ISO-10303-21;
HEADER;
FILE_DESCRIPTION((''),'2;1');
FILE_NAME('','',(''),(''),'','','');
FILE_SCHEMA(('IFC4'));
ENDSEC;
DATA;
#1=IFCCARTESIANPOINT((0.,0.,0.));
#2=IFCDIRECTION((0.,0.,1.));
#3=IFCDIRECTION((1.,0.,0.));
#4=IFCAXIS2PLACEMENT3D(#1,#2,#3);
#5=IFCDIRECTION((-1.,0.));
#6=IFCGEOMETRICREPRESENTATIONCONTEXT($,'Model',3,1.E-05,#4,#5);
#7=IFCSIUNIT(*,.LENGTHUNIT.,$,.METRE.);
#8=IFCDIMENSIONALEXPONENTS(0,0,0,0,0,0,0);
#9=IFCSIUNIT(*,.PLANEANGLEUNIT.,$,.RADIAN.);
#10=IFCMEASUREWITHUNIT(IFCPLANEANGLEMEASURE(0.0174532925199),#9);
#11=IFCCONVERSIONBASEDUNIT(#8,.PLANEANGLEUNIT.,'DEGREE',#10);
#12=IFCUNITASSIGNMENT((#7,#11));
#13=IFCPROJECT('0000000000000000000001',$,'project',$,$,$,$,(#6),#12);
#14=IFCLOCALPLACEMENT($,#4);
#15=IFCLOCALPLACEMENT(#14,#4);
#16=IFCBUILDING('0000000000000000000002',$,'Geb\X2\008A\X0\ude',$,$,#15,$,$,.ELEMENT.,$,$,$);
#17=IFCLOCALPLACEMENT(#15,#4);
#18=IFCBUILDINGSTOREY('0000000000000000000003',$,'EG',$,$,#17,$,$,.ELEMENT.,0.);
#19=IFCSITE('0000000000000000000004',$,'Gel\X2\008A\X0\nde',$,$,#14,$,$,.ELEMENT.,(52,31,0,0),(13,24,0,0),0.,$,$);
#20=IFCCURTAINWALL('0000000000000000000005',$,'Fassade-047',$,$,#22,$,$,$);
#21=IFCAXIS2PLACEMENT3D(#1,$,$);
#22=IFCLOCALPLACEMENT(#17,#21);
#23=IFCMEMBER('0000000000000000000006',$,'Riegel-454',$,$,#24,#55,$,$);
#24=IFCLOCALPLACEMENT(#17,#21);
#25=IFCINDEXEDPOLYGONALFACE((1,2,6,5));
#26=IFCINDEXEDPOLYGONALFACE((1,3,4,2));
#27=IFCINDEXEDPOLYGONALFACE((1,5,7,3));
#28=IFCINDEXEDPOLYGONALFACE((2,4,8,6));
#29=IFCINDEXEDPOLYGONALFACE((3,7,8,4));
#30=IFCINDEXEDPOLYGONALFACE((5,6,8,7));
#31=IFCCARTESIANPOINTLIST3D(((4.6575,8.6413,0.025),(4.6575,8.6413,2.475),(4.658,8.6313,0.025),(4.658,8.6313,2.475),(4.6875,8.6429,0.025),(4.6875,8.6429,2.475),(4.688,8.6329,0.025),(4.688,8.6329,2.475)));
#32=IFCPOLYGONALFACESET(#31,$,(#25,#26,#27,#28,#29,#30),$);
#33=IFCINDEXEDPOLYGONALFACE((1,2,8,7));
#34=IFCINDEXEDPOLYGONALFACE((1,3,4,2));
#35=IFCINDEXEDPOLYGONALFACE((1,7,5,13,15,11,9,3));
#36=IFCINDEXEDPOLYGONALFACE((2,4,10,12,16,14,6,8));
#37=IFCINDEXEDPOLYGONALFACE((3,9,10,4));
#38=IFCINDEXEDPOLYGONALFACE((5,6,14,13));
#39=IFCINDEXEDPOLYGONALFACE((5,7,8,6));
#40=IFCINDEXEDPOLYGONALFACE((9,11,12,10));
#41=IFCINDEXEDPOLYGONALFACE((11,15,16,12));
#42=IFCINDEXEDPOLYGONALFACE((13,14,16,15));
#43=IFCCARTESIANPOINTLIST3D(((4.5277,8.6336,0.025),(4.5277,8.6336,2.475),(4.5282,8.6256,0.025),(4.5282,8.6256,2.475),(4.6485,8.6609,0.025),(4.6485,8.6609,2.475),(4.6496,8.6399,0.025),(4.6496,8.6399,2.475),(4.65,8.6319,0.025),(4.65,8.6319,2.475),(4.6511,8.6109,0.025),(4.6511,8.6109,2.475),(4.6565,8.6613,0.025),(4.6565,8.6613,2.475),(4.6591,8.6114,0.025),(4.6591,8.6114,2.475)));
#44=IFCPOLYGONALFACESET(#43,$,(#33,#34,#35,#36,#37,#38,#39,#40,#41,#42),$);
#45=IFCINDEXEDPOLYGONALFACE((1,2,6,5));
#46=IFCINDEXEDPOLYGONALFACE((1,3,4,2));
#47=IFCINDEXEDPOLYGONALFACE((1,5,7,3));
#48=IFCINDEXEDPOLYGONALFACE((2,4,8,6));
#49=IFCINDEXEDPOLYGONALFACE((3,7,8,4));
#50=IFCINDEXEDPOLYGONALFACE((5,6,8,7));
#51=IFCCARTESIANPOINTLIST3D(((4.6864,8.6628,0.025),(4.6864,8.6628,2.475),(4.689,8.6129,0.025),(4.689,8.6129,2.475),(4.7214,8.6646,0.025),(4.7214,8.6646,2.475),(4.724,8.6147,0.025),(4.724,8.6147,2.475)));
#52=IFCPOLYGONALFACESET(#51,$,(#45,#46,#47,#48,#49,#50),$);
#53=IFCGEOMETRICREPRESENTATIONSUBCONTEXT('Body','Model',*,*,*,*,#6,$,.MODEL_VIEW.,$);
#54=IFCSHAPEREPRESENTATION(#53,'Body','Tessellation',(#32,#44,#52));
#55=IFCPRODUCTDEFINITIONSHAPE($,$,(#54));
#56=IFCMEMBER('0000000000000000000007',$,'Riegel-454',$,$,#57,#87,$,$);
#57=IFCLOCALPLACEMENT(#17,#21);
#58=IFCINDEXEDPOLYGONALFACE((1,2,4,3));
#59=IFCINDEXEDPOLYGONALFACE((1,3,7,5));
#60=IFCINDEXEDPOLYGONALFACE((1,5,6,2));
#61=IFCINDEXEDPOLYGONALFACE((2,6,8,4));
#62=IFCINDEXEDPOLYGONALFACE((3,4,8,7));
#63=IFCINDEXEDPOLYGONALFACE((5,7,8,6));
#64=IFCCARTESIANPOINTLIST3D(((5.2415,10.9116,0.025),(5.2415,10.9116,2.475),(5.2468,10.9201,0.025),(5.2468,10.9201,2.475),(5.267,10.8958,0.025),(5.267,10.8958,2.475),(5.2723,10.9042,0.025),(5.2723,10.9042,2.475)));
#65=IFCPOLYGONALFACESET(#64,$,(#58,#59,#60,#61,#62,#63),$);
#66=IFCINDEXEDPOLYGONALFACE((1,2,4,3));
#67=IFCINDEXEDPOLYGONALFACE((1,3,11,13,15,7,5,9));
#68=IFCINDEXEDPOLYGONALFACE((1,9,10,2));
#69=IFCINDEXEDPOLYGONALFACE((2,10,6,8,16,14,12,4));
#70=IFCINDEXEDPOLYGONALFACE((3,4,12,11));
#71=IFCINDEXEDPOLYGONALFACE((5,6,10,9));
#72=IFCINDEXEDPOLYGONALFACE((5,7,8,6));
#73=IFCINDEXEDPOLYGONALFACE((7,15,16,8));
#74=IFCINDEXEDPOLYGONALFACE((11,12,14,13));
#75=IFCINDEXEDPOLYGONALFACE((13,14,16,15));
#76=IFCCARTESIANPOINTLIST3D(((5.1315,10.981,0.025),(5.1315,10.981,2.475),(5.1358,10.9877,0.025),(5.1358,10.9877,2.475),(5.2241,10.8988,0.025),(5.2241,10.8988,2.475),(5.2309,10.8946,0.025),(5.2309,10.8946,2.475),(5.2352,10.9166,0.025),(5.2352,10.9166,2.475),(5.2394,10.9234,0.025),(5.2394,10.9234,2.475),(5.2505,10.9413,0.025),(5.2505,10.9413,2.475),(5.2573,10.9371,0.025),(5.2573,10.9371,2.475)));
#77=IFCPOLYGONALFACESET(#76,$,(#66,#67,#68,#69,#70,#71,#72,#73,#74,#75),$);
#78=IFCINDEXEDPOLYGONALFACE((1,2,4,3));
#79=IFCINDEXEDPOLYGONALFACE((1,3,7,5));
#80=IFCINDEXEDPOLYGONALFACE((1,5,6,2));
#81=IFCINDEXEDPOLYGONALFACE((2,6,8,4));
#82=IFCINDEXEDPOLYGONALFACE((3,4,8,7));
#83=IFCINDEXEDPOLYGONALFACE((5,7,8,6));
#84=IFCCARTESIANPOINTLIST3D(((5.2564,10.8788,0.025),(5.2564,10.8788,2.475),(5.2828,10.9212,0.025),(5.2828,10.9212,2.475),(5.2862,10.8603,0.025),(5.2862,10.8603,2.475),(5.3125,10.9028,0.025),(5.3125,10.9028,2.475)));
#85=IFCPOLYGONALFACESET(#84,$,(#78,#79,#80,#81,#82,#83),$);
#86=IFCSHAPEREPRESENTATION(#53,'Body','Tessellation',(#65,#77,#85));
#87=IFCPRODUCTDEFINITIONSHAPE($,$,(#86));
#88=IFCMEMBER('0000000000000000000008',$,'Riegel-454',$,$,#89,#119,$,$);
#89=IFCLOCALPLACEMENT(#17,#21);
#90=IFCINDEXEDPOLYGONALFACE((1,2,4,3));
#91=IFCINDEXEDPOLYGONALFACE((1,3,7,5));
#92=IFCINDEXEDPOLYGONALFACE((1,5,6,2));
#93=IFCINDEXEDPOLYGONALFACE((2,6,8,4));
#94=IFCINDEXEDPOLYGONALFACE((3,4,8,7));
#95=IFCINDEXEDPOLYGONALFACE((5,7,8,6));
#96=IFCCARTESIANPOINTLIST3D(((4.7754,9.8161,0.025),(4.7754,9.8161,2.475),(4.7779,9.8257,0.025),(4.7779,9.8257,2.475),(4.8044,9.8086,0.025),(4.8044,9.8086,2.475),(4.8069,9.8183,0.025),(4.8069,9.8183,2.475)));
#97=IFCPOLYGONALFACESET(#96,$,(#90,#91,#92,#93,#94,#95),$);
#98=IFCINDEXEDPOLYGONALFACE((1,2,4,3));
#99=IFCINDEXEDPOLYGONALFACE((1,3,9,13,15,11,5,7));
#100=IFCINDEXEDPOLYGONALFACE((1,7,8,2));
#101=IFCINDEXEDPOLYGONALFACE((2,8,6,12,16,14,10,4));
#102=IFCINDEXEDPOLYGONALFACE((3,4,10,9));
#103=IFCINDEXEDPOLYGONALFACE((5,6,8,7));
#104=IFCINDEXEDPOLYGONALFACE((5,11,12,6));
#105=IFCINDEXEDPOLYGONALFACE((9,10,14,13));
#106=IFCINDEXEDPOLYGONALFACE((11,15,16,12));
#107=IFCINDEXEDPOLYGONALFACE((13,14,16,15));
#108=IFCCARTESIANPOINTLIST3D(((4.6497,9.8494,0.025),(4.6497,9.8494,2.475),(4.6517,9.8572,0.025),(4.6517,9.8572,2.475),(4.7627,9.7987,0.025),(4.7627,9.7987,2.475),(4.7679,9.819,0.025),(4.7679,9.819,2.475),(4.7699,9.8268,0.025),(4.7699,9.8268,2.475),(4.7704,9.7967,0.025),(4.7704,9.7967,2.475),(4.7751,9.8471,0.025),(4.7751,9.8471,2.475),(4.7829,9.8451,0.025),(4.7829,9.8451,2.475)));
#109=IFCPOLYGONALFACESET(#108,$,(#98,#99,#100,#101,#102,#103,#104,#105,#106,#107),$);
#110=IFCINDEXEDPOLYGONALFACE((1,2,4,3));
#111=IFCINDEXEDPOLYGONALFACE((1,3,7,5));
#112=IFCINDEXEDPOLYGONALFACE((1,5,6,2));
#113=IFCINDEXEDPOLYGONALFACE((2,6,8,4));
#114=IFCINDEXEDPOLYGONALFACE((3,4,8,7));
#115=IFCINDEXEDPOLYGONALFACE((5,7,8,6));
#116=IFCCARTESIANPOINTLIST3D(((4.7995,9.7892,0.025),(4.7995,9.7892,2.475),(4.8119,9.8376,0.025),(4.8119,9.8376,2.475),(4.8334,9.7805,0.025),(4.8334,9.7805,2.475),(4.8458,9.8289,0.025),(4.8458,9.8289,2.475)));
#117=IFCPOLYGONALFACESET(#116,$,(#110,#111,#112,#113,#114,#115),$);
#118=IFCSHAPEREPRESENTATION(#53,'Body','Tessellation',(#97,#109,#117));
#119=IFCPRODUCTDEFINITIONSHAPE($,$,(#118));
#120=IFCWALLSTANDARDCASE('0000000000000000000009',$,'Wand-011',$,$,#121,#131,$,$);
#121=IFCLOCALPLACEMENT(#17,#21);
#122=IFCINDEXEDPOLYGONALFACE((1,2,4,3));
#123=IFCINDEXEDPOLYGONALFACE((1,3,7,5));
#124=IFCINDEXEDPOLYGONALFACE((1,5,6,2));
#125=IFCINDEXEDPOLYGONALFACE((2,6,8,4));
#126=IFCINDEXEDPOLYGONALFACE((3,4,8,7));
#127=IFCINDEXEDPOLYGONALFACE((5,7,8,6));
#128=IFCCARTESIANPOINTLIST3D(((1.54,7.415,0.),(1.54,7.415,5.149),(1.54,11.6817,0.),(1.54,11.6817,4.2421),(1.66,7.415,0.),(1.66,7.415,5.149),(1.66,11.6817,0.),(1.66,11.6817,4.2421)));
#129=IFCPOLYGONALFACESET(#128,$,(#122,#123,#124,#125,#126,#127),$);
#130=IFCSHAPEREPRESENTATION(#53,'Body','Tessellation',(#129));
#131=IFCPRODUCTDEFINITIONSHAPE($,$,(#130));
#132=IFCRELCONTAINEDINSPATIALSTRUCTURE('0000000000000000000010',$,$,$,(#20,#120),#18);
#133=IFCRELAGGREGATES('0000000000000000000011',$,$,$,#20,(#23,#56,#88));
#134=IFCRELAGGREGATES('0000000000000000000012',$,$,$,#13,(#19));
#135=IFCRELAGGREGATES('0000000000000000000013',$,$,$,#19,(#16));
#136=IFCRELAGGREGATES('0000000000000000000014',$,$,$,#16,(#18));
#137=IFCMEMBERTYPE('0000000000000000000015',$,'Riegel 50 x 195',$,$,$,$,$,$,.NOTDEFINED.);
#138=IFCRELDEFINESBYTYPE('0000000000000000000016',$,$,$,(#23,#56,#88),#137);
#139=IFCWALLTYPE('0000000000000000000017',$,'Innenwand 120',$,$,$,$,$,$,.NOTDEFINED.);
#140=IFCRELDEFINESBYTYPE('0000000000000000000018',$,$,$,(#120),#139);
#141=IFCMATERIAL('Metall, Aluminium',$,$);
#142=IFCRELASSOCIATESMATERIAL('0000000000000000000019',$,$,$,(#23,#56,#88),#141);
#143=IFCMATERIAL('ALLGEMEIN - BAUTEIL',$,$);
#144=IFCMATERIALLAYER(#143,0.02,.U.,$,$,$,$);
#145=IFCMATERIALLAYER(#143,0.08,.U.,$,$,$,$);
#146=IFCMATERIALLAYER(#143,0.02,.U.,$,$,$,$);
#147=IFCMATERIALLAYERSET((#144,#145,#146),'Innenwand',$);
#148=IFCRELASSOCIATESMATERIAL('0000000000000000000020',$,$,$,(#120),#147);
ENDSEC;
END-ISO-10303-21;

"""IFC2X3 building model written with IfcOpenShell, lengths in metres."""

from ifc_helpers import new_model, entity, si_unit, converted_unit, direction, frame, origin_with_axes, place, context, subcontext, project, spatial, polyline, outline, extrude, clip, halfspace, material, layer, layer_set, layer_usage, type_object, element, aggregate, save


model = new_model("IFC2X3")

# Units and contexts
model_context = context("Model", 3, precision=1e-05, world=origin_with_axes(), true_north=direction((-1.0, 0.0)))
body_context = subcontext(model_context, "Body", "Model", "MODEL_VIEW")
ifc_project = project(units=[si_unit("LENGTHUNIT", "METRE"), converted_unit("PLANEANGLEUNIT", "DEGREE", entity("IfcPlaneAngleMeasure", 0.0174532925199), si_unit("PLANEANGLEUNIT", "RADIAN"), dimensions=[0, 0, 0, 0, 0, 0, 0])], contexts=[model_context])

# Site, building, storey
site_placement = place(None, origin_with_axes())
site = spatial("IfcSite", under=ifc_project, at=site_placement, Name="Gel\u008ande", CompositionType="ELEMENT", RefLatitude=(52, 31, 0, 0), RefLongitude=(13, 24, 0, 0), RefElevation=0.0)
building_placement = place(site_placement, origin_with_axes())
building = spatial("IfcBuilding", under=site, at=building_placement, Name="Geb\u008aude", CompositionType="ELEMENT")
storey_placement = place(building_placement, origin_with_axes())
storey = spatial("IfcBuildingStorey", under=building, at=storey_placement, Name="EG", CompositionType="ELEMENT", Elevation=0.0)

# Curtain wall, members
curtain_wall_placement = place(storey_placement, frame((7.6056, 12.5904, 0.0), z_axis=(0.0, 0.0, 1.0), x_axis=(1.0, 0.0, 0.0)))
curtain_wall = element("IfcCurtainWall", 1, at=curtain_wall_placement, inside=storey, Name="Fassade-047")
ifc_material_1 = material(Name="Metall, Aluminium")
member_type_1 = type_object("IfcMemberType", Name="Riegel 50 x 195", PredefinedType="NOTDEFINED")
member_1_placement = place(curtain_wall_placement, frame((-2.9328, -3.9533, 0.0), z_axis=(0.0, 0.0, 1.0), x_axis=(-0.051729, 0.998661, 0.0)))
member_1 = element("IfcMember", 2, at=member_1_placement, type_object=member_type_1, material=ifc_material_1, Name="Riegel-454", context=body_context, shape_type="SweptSolid", body=[
    extrude(outline(polyline([(-0.0152, 0.0042), (-0.0147, -0.0058), (0.0152, -0.0042), (0.0147, 0.0058), (-0.0152, 0.0042)])), frame((0.0, 0.0, 0.025), z_axis=(0.0, 0.0, 1.0), x_axis=(-0.051729, -0.998661, 0.0)), (0.0, 0.0, 1.0), 2.45),
    extrude(outline(polyline([(-0.145, -0.0035), (-0.1446, -0.0115), (-0.0228, -0.0052), (-0.0217, -0.0262), (-0.0137, -0.0257), (-0.0163, 0.0242), (-0.0243, 0.0238), (-0.0232, 0.0028), (-0.145, -0.0035)])), frame((0.0, 0.0, 0.025), z_axis=(0.0, 0.0, 1.0), x_axis=(-0.051729, -0.998661, 0.0)), (0.0, 0.0, 1.0), 2.45),
    extrude(outline(polyline([(0.0512, -0.0224), (0.0486, 0.0276), (0.0137, 0.0257), (0.0163, -0.0242), (0.0512, -0.0224)])), frame((0.0, 0.0, 0.025), z_axis=(0.0, 0.0, 1.0), x_axis=(-0.051729, -0.998661, 0.0)), (0.0, 0.0, 1.0), 2.45),
])
member_2_placement = place(curtain_wall_placement, frame((-2.3487, -1.6825, 0.0), z_axis=(0.0, 0.0, 1.0), x_axis=(0.527191, 0.849747, 0.0)))
member_2 = element("IfcMember", 3, at=member_2_placement, type_object=member_type_1, material=ifc_material_1, Name="Riegel-454", context=body_context, shape_type="SweptSolid", body=[
    extrude(outline(polyline([(-0.0101, 0.0122), (-0.0154, 0.0037), (0.0101, -0.0122), (0.0154, -0.0037), (-0.0101, 0.0122)])), frame((0.0, 0.0, 0.025), z_axis=(0.0, 0.0, 1.0), x_axis=(0.527191, -0.849747, 0.0)), (0.0, 0.0, 1.0), 2.45),
    extrude(outline(polyline([(-0.1211, 0.0798), (-0.1253, 0.073), (-0.0217, 0.0087), (-0.0327, -0.0091), (-0.0259, -0.0133), (0.0004, 0.0292), (-0.0064, 0.0334), (-0.0174, 0.0155), (-0.1211, 0.0798)])), frame((0.0, 0.0, 0.025), z_axis=(0.0, 0.0, 1.0), x_axis=(0.527191, -0.849747, 0.0)), (0.0, 0.0, 1.0), 2.45),
    extrude(outline(polyline([(0.0293, -0.0476), (0.0557, -0.0051), (0.0259, 0.0133), (-0.0004, -0.0292), (0.0293, -0.0476)])), frame((0.0, 0.0, 0.025), z_axis=(0.0, 0.0, 1.0), x_axis=(0.527191, -0.849747, 0.0)), (0.0, 0.0, 1.0), 2.45),
])
member_3_placement = place(curtain_wall_placement, frame((-2.8144, -2.7732, 0.0), z_axis=(0.0, 0.0, 1.0), x_axis=(0.249118, 0.968473, 0.0)))
member_3 = element("IfcMember", 4, at=member_3_placement, type_object=member_type_1, material=ifc_material_1, Name="Riegel-454", context=body_context, shape_type="SweptSolid", body=[
    extrude(outline(polyline([(-0.0133, 0.0086), (-0.0158, -0.0011), (0.0133, -0.0086), (0.0158, 0.0011), (-0.0133, 0.0086)])), frame((0.0, 0.0, 0.025), z_axis=(0.0, 0.0, 1.0), x_axis=(0.249118, -0.968473, 0.0)), (0.0, 0.0, 1.0), 2.45),
    extrude(outline(polyline([(-0.1394, 0.04), (-0.1414, 0.0322), (-0.0233, 0.0019), (-0.0285, -0.0185), (-0.0208, -0.0205), (-0.0083, 0.0279), (-0.016, 0.0299), (-0.0213, 0.0096), (-0.1394, 0.04)])), frame((0.0, 0.0, 0.025), z_axis=(0.0, 0.0, 1.0), x_axis=(0.249118, -0.968473, 0.0)), (0.0, 0.0, 1.0), 2.45),
    extrude(outline(polyline([(0.0422, -0.0367), (0.0547, 0.0118), (0.0208, 0.0205), (0.0083, -0.0279), (0.0422, -0.0367)])), frame((0.0, 0.0, 0.025), z_axis=(0.0, 0.0, 1.0), x_axis=(0.249118, -0.968473, 0.0)), (0.0, 0.0, 1.0), 2.45),
])

# Shared definitions
ifc_material_2 = material(Name="ALLGEMEIN - BAUTEIL")

aggregate(curtain_wall, [member_1, member_2, member_3])

# Wall
ifc_layer_1 = layer(ifc_material_2, 0.02, ventilated="UNKNOWN")
ifc_layer_2 = layer(ifc_material_2, 0.08, ventilated="UNKNOWN")
ifc_layer_3 = layer(ifc_material_2, 0.02, ventilated="UNKNOWN")
ifc_layer_set_1 = layer_set([ifc_layer_1, ifc_layer_2, ifc_layer_3], Name="Innenwand")
ifc_layer_usage_1 = layer_usage(ifc_layer_set_1, "AXIS2", "POSITIVE", 0.0)
wall_type = type_object("IfcWallType", Name="Innenwand 120", PredefinedType="NOTDEFINED")
wall_placement = place(storey_placement, frame((1.54, 11.6817, 0.0), z_axis=(0.0, 0.0, 1.0), x_axis=(0.0, -1.0, 0.0)))
element("IfcWallStandardCase", 5, at=wall_placement, inside=storey, type_object=wall_type, material=ifc_layer_usage_1, Name="Wand-011", context=body_context, shape_type="Clipping", body=[
    clip(extrude(outline(polyline([(0.0, 0.0), (4.2667, 0.0), (4.2667, 0.12), (0.0, 0.12), (0.0, 0.0)])), origin_with_axes(), (0.0, 0.0, 1.0), 7.0), halfspace(frame((-0.8627, 0.0, 4.0587), z_axis=(0.207912, 0.0, -0.978148), x_axis=(0.978148, 0.0, 0.207912)), True)),
])

save(model, "model.ifc")
